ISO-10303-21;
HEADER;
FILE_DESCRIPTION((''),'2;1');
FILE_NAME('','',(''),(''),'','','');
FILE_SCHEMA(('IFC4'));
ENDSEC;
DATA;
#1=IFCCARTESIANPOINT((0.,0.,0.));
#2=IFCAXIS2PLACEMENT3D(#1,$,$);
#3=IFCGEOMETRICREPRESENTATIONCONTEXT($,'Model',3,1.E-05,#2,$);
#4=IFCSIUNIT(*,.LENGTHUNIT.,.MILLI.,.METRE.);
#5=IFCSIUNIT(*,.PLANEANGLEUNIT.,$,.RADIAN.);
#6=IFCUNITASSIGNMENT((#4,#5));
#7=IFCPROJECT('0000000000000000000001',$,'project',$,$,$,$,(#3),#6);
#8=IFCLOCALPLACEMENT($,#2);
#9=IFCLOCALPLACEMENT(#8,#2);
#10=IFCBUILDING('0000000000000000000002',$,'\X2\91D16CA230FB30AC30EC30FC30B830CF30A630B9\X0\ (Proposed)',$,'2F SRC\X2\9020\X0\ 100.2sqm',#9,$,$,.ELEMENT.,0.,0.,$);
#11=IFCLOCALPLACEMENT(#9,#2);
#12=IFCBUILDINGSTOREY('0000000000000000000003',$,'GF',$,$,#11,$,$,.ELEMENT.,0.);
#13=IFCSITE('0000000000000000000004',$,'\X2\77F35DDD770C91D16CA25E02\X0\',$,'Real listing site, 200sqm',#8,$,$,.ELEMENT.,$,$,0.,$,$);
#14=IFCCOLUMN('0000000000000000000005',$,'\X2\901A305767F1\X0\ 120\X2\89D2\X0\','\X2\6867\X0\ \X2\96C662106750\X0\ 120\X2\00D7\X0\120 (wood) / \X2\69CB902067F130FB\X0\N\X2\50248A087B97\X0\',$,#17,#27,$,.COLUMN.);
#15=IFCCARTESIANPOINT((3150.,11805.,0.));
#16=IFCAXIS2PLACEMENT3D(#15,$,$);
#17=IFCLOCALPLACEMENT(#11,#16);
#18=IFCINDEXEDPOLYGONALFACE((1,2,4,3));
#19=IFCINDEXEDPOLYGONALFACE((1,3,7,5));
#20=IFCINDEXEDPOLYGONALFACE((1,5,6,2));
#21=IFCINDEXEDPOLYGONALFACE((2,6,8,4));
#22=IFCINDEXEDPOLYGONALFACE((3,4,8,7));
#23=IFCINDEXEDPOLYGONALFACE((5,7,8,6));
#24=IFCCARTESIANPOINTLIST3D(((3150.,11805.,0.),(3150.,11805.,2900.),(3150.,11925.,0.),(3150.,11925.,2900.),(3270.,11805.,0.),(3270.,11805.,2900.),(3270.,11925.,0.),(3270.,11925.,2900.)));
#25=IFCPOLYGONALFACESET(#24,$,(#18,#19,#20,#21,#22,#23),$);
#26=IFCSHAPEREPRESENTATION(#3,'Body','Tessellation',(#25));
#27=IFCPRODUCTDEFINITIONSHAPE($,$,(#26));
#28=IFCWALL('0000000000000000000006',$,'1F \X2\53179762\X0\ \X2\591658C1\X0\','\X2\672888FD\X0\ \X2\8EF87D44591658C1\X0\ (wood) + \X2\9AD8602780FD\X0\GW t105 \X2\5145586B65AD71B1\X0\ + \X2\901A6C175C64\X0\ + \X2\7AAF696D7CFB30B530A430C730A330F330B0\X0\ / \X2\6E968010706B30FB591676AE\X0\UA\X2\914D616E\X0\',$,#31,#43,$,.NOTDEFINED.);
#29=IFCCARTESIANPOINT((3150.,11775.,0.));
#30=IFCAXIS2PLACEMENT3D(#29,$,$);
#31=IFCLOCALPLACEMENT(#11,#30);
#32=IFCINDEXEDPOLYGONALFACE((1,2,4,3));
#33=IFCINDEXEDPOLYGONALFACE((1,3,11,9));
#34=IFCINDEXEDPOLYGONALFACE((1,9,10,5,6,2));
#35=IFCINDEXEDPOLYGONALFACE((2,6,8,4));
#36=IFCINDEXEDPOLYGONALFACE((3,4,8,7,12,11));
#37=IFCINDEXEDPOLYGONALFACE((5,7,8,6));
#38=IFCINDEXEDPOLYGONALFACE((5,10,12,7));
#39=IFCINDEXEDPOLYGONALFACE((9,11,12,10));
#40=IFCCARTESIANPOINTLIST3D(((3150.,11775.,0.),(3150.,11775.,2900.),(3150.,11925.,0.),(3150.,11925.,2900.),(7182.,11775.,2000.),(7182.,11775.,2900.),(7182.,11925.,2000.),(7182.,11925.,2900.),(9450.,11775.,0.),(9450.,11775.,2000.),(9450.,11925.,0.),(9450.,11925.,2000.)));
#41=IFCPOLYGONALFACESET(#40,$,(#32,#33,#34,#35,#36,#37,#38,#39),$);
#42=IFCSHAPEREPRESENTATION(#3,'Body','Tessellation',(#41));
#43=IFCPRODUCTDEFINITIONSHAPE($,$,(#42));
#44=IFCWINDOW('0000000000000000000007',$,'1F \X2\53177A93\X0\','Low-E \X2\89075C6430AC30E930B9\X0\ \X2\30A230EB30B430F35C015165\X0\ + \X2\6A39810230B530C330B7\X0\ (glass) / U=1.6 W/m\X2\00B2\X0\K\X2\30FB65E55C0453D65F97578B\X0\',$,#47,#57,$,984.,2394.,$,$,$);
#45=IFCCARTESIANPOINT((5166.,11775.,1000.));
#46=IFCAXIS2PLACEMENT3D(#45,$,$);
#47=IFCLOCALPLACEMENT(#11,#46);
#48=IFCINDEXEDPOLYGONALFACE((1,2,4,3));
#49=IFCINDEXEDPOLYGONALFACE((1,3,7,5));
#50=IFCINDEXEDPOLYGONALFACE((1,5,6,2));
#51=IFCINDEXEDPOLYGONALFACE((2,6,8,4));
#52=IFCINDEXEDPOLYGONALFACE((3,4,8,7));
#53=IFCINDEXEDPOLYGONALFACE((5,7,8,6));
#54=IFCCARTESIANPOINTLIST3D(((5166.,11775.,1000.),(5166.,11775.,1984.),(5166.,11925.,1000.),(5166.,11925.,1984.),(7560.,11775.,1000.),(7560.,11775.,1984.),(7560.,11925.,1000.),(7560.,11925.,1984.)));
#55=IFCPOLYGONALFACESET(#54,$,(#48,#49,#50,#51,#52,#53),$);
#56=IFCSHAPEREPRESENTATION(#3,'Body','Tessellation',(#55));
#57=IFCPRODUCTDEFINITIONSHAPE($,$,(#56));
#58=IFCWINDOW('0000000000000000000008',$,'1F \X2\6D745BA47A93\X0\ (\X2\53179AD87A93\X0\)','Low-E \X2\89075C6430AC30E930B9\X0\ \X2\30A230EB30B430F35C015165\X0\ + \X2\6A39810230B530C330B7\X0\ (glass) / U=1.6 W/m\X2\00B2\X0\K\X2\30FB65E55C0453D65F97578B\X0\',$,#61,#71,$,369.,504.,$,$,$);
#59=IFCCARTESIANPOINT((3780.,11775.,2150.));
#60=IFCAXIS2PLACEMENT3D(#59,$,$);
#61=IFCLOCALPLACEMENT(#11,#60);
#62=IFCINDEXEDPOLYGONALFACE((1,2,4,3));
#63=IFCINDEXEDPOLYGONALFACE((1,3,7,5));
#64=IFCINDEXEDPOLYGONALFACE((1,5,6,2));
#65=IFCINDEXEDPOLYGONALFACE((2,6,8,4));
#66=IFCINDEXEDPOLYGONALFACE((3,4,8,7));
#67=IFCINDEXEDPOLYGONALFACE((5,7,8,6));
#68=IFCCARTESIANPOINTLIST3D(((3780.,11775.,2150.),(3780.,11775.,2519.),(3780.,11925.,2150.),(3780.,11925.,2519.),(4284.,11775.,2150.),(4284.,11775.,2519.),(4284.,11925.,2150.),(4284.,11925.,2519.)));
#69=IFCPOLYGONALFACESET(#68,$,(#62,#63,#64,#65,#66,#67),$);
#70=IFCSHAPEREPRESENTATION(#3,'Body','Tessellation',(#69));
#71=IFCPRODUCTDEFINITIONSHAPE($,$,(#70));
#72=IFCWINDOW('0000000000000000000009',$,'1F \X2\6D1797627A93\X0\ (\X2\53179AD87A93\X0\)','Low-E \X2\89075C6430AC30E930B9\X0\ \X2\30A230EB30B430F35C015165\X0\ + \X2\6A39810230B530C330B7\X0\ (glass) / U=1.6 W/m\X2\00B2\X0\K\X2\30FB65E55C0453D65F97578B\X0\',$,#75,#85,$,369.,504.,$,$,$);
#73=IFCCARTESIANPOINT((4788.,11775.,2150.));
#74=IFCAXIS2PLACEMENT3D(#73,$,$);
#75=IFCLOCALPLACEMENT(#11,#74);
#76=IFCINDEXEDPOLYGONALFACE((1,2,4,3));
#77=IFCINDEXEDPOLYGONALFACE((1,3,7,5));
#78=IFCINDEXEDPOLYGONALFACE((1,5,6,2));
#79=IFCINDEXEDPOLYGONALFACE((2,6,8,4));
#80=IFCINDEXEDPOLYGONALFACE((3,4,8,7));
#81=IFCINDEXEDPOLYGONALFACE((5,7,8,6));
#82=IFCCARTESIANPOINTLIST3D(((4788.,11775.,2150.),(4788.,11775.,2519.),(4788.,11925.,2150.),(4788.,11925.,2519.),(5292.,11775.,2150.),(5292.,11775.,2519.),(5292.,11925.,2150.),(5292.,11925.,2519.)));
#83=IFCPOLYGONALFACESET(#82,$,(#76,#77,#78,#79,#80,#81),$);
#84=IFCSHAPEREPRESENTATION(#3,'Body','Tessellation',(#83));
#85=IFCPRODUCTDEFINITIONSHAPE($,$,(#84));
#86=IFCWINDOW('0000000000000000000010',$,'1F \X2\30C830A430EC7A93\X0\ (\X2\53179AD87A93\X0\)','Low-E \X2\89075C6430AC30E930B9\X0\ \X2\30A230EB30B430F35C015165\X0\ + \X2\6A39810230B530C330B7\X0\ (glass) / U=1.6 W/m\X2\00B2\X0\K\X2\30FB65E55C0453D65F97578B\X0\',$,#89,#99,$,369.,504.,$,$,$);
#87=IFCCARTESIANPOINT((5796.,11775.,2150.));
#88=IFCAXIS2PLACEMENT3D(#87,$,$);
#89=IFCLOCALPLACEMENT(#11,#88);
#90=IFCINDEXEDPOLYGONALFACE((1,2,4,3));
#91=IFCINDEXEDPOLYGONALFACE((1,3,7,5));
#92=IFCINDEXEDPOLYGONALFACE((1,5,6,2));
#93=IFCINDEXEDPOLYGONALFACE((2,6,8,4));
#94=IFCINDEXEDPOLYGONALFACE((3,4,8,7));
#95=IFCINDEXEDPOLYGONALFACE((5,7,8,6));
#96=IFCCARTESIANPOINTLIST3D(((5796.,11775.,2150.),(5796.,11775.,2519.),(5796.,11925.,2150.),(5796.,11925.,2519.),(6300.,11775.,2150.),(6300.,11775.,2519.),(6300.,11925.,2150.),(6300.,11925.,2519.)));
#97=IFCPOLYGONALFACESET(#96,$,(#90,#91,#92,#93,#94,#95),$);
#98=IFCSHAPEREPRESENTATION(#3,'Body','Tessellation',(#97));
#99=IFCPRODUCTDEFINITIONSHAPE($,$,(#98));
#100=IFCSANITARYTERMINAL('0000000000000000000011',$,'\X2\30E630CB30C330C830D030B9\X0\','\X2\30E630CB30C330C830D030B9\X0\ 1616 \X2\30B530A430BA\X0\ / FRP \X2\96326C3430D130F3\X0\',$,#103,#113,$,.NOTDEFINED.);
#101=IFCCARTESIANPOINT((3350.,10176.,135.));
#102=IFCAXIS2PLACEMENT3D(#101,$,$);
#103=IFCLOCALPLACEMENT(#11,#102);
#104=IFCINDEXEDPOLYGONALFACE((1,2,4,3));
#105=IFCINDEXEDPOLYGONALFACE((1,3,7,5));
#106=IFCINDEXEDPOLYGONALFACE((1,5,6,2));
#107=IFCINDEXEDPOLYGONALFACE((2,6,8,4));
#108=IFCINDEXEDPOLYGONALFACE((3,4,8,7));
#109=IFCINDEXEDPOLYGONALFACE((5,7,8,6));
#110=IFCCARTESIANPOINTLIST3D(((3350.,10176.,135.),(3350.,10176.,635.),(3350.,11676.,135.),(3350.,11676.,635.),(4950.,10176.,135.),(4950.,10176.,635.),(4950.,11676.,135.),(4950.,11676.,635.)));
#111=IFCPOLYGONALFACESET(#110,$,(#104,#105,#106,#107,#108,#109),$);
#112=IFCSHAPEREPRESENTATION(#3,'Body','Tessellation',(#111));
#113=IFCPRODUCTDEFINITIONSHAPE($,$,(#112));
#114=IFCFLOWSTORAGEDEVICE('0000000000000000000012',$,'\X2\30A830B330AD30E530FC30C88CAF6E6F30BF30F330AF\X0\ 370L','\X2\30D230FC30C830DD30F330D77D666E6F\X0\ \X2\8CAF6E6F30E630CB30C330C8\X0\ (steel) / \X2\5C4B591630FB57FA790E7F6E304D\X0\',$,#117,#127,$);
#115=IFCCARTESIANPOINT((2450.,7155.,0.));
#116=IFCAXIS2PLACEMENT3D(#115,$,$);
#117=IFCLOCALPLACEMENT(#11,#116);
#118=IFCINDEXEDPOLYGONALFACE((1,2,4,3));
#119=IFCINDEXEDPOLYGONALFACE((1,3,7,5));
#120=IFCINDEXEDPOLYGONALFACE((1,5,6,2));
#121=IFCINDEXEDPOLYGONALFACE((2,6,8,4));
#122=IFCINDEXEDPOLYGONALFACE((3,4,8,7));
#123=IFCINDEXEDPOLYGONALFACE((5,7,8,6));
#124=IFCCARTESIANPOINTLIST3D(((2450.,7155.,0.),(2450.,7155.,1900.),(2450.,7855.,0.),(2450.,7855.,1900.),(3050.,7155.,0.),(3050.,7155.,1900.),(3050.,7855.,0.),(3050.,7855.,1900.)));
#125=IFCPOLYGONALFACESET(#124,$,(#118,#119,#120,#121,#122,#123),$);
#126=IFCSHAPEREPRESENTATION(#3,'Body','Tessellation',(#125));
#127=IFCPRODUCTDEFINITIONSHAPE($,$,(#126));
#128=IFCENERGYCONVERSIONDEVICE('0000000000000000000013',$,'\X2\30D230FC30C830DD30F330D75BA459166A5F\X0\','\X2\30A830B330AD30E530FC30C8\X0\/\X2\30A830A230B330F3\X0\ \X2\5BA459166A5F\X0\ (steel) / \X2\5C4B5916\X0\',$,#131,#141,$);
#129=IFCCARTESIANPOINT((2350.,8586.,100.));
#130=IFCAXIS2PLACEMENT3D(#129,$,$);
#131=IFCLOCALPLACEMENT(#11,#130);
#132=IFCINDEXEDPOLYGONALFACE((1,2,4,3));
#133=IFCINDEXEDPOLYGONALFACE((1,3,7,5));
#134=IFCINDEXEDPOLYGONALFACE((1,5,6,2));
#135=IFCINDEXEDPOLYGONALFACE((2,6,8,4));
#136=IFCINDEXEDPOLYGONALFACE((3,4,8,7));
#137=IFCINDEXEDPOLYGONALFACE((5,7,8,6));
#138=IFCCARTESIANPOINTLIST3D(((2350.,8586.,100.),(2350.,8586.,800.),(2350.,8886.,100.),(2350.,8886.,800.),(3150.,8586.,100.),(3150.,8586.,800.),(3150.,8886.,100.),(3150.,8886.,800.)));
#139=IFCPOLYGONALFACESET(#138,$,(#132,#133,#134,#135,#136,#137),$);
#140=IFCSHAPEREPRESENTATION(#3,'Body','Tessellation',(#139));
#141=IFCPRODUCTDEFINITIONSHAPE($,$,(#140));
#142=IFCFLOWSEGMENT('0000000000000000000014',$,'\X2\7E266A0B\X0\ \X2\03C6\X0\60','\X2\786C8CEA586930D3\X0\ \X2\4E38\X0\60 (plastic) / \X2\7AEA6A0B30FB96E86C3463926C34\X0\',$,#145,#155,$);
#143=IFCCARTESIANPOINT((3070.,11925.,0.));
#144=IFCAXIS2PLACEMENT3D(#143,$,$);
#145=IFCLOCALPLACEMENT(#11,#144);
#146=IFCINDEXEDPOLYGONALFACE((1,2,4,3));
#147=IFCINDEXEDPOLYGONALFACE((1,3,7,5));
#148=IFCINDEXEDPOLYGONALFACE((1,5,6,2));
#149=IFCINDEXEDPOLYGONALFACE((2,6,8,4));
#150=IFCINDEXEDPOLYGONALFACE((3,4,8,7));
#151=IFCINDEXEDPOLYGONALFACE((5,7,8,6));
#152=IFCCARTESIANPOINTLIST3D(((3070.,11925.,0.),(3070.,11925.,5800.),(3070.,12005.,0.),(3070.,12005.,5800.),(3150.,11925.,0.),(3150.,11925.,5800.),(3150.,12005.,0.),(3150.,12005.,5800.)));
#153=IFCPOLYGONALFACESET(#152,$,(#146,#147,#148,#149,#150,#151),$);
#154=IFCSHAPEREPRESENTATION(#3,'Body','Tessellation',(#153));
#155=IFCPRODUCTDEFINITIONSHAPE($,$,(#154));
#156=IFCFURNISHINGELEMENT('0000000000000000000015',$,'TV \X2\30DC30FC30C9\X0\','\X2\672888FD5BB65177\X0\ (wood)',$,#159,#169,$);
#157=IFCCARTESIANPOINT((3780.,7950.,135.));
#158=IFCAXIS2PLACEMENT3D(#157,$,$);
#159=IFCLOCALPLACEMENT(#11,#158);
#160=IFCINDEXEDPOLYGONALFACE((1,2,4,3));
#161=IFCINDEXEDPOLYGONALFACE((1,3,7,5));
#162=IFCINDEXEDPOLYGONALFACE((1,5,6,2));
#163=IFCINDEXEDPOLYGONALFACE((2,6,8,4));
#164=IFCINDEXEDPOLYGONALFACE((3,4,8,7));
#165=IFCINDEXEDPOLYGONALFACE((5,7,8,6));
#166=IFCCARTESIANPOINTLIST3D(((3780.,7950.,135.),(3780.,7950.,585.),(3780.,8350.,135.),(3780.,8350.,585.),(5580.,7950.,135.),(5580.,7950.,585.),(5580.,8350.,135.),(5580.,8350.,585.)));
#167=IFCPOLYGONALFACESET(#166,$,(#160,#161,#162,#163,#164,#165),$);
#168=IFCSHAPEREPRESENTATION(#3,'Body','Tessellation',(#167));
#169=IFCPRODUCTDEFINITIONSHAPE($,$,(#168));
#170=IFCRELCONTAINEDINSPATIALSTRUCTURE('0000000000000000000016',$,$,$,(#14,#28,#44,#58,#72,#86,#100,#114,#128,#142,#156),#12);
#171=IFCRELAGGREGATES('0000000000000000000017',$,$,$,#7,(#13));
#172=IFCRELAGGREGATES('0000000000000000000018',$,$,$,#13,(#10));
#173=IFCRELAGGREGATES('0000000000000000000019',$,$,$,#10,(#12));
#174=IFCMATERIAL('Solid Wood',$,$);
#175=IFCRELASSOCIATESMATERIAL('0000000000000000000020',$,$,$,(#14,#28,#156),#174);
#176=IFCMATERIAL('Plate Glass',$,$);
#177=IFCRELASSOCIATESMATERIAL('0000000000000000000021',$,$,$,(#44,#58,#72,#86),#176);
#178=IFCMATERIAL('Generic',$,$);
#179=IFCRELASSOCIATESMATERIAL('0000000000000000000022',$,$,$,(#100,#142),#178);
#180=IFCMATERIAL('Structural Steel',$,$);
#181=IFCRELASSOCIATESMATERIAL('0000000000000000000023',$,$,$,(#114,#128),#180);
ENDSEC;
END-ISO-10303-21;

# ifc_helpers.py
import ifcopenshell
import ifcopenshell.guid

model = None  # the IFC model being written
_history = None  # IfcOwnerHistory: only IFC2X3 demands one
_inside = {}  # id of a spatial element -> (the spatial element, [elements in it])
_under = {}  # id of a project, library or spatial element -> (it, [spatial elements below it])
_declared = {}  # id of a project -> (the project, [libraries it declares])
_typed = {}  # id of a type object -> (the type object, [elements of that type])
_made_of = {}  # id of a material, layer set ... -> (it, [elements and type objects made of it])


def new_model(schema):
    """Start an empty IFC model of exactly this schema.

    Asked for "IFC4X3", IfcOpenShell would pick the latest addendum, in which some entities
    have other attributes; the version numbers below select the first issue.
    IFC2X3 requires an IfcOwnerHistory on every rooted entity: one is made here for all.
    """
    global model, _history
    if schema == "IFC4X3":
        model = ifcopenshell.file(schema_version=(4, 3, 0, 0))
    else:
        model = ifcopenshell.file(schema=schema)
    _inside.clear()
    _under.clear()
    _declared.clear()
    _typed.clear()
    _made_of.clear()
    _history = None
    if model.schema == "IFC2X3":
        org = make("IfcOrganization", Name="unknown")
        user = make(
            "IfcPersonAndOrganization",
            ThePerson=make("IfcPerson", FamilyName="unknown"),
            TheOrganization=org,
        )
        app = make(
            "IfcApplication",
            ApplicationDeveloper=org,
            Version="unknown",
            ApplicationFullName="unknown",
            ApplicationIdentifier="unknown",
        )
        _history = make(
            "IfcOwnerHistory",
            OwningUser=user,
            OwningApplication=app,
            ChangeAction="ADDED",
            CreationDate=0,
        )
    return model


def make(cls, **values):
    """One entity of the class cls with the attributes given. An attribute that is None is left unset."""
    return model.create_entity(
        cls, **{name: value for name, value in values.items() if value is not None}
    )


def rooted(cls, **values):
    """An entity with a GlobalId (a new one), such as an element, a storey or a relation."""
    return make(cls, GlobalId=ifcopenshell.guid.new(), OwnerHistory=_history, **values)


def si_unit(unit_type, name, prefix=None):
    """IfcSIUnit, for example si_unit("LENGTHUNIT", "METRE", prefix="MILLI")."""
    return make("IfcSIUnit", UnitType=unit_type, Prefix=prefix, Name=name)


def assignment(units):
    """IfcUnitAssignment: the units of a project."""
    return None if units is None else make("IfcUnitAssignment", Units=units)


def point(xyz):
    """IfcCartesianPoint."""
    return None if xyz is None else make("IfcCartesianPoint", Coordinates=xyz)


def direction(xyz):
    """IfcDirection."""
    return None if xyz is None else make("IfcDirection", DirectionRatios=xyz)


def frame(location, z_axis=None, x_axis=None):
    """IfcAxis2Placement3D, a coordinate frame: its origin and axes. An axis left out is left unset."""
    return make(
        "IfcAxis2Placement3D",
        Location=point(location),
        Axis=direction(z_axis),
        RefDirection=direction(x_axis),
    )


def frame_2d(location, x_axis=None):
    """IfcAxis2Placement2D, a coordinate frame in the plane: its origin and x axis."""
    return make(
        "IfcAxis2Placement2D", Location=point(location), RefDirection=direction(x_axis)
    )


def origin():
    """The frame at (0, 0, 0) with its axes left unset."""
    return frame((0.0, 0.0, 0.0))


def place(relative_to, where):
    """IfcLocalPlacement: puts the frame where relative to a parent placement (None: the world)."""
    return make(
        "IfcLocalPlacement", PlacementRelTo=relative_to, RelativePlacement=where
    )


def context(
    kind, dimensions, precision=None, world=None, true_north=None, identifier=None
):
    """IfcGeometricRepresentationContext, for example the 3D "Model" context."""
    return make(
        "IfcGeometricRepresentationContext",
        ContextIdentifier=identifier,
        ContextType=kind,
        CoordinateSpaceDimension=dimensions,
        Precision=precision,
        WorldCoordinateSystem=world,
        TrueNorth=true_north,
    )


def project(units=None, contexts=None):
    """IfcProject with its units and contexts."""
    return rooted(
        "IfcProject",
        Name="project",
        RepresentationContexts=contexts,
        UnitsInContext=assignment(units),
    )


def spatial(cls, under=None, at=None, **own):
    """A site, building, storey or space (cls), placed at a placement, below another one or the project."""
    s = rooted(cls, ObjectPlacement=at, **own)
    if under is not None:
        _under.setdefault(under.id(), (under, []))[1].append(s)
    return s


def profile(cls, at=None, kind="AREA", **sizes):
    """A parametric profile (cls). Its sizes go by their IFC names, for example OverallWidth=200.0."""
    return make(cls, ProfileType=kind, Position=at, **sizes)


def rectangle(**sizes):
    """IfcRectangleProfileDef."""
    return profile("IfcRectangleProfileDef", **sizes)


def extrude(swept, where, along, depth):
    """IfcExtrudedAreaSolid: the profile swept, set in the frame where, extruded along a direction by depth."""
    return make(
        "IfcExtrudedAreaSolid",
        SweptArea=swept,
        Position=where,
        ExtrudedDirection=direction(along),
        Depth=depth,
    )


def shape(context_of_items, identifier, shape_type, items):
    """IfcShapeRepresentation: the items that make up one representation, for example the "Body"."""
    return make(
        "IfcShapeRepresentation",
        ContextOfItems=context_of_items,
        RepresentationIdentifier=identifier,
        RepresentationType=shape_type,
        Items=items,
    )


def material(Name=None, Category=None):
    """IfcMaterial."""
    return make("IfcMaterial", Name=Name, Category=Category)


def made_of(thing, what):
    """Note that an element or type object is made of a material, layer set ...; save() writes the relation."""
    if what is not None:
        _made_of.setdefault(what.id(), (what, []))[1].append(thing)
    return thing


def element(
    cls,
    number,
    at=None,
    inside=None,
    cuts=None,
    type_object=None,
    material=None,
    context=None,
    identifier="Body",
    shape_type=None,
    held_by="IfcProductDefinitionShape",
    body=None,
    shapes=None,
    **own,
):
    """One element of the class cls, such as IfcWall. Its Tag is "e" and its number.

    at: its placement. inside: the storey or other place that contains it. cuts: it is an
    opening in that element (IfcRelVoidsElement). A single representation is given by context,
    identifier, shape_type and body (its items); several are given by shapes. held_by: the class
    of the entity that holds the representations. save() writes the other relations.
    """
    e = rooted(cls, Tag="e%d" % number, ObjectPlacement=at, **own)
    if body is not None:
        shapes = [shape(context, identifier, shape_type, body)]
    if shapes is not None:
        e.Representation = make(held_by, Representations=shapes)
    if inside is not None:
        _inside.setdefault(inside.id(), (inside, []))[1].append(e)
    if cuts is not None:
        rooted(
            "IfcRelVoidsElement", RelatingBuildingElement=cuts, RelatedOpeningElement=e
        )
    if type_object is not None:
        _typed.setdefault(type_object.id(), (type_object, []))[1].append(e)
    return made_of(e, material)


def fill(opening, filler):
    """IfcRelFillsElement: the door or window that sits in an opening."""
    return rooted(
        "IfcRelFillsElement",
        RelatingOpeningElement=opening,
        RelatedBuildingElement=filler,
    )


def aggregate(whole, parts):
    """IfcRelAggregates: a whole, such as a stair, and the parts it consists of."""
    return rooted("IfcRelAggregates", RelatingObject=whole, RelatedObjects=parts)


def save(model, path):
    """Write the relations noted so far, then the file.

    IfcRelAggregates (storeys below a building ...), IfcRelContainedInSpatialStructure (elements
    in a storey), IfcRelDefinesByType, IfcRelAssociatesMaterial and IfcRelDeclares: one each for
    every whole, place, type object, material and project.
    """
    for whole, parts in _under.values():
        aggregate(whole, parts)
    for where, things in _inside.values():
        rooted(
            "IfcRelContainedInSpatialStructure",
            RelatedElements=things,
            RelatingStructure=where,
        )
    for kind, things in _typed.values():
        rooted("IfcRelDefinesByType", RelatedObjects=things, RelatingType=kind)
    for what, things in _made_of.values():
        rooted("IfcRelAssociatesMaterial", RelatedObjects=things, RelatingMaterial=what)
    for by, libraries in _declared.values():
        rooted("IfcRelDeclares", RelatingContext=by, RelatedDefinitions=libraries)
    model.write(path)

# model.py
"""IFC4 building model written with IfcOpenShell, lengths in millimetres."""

from ifc_helpers import new_model, si_unit, frame, frame_2d, origin, place, context, project, spatial, rectangle, extrude, material, element, fill, save


model = new_model("IFC4")

# Units and contexts
model_context = context("Model", 3, precision=1e-05, world=origin())
ifc_project = project(units=[si_unit("LENGTHUNIT", "METRE", prefix="MILLI"), si_unit("PLANEANGLEUNIT", "RADIAN")], contexts=[model_context])

# Site, building, storey
site_placement = place(None, origin())
site = spatial("IfcSite", under=ifc_project, at=site_placement, Name="石川県金沢市", ObjectType="Real listing site, 200sqm", CompositionType="ELEMENT", RefElevation=0.0)
building_placement = place(site_placement, origin())
building = spatial("IfcBuilding", under=site, at=building_placement, Name="金沢・ガレージハウス (Proposed)", ObjectType="2F SRC造 100.2sqm", CompositionType="ELEMENT", ElevationOfRefHeight=0.0, ElevationOfTerrain=0.0)
storey_placement = place(building_placement, origin())
storey = spatial("IfcBuildingStorey", under=building, at=storey_placement, Name="GF", CompositionType="ELEMENT", Elevation=0.0)

# Column
ifc_material_1 = material(Name="Solid Wood")
column_1_placement = place(storey_placement, frame((3150.0, 11805.0, 0.0)))
element("IfcColumn", 1, at=column_1_placement, inside=storey, material=ifc_material_1, Name="通し柱 120角", Description="桧 集成材 120×120 (wood) / 構造柱・N値計算", PredefinedType="COLUMN", context=model_context, shape_type="SweptSolid", body=[
    extrude(rectangle(XDim=120.0, YDim=120.0, at=frame_2d((60.0, 60.0))), frame((3150.0, 11805.0, 0.0)), (0.0, 0.0, 1.0), 2900.0),
])

# Wall, openings, windows
wall_1_placement = place(storey_placement, frame((3150.0, 11775.0, 0.0)))
wall_1 = element("IfcWall", 2, at=wall_1_placement, inside=storey, material=ifc_material_1, Name="1F 北面 外壁", Description="木製 軸組外壁 (wood) + 高性能GW t105 充填断熱 + 通気層 + 窯業系サイディング / 準耐火・外皮UA配慮", PredefinedType="NOTDEFINED", context=model_context, shape_type="SweptSolid", body=[
    extrude(rectangle(XDim=6300.0, YDim=150.0, at=frame_2d((3150.0, 75.0))), frame((3150.0, 11775.0, 0.0)), (0.0, 0.0, 1.0), 2900.0),
])
opening_1_placement = place(storey_placement, frame((5166.0, 11775.0, 1000.0)))
opening_1 = element("IfcOpeningElement", 3, at=opening_1_placement, cuts=wall_1, PredefinedType="NOTDEFINED", context=model_context, shape_type="SweptSolid", body=[
    extrude(rectangle(XDim=2394.0, YDim=150.0, at=frame_2d((1197.0, 75.0))), frame((5166.0, 11775.0, 1000.0)), (0.0, 0.0, 1.0), 984.0),
])
opening_2_placement = place(storey_placement, frame((3780.0, 11775.0, 2150.0)))
opening_2 = element("IfcOpeningElement", 4, at=opening_2_placement, cuts=wall_1, PredefinedType="NOTDEFINED", context=model_context, shape_type="SweptSolid", body=[
    extrude(rectangle(XDim=504.0, YDim=150.0, at=frame_2d((252.0, 75.0))), frame((3780.0, 11775.0, 2150.0)), (0.0, 0.0, 1.0), 369.0),
])
opening_3_placement = place(storey_placement, frame((4788.0, 11775.0, 2150.0)))
opening_3 = element("IfcOpeningElement", 5, at=opening_3_placement, cuts=wall_1, PredefinedType="NOTDEFINED", context=model_context, shape_type="SweptSolid", body=[
    extrude(rectangle(XDim=504.0, YDim=150.0, at=frame_2d((252.0, 75.0))), frame((4788.0, 11775.0, 2150.0)), (0.0, 0.0, 1.0), 369.0),
])
opening_4_placement = place(storey_placement, frame((5796.0, 11775.0, 2150.0)))
opening_4 = element("IfcOpeningElement", 6, at=opening_4_placement, cuts=wall_1, PredefinedType="NOTDEFINED", context=model_context, shape_type="SweptSolid", body=[
    extrude(rectangle(XDim=504.0, YDim=150.0, at=frame_2d((252.0, 75.0))), frame((5796.0, 11775.0, 2150.0)), (0.0, 0.0, 1.0), 369.0),
])
ifc_material_2 = material(Name="Plate Glass")
window_1_placement = place(storey_placement, frame((5166.0, 11775.0, 1000.0)))
window_1 = element("IfcWindow", 7, at=window_1_placement, inside=storey, material=ifc_material_2, Name="1F 北窓", Description="Low-E 複層ガラス アルゴン封入 + 樹脂サッシ (glass) / U=1.6 W/m²K・日射取得型", OverallHeight=984.0, OverallWidth=2394.0, context=model_context, shape_type="SweptSolid", body=[
    extrude(rectangle(XDim=2394.0, YDim=150.0, at=frame_2d((1197.0, 75.0))), frame((5166.0, 11775.0, 1000.0)), (0.0, 0.0, 1.0), 984.0),
])
fill(opening_1, window_1)
window_2_placement = place(storey_placement, frame((3780.0, 11775.0, 2150.0)))
window_2 = element("IfcWindow", 8, at=window_2_placement, inside=storey, material=ifc_material_2, Name="1F 浴室窓 (北高窓)", Description="Low-E 複層ガラス アルゴン封入 + 樹脂サッシ (glass) / U=1.6 W/m²K・日射取得型", OverallHeight=369.0, OverallWidth=504.0, context=model_context, shape_type="SweptSolid", body=[
    extrude(rectangle(XDim=504.0, YDim=150.0, at=frame_2d((252.0, 75.0))), frame((3780.0, 11775.0, 2150.0)), (0.0, 0.0, 1.0), 369.0),
])
fill(opening_2, window_2)
window_3_placement = place(storey_placement, frame((4788.0, 11775.0, 2150.0)))
window_3 = element("IfcWindow", 9, at=window_3_placement, inside=storey, material=ifc_material_2, Name="1F 洗面窓 (北高窓)", Description="Low-E 複層ガラス アルゴン封入 + 樹脂サッシ (glass) / U=1.6 W/m²K・日射取得型", OverallHeight=369.0, OverallWidth=504.0, context=model_context, shape_type="SweptSolid", body=[
    extrude(rectangle(XDim=504.0, YDim=150.0, at=frame_2d((252.0, 75.0))), frame((4788.0, 11775.0, 2150.0)), (0.0, 0.0, 1.0), 369.0),
])
fill(opening_3, window_3)
window_4_placement = place(storey_placement, frame((5796.0, 11775.0, 2150.0)))
window_4 = element("IfcWindow", 10, at=window_4_placement, inside=storey, material=ifc_material_2, Name="1F トイレ窓 (北高窓)", Description="Low-E 複層ガラス アルゴン封入 + 樹脂サッシ (glass) / U=1.6 W/m²K・日射取得型", OverallHeight=369.0, OverallWidth=504.0, context=model_context, shape_type="SweptSolid", body=[
    extrude(rectangle(XDim=504.0, YDim=150.0, at=frame_2d((252.0, 75.0))), frame((5796.0, 11775.0, 2150.0)), (0.0, 0.0, 1.0), 369.0),
])
fill(opening_4, window_4)

# Sanitary terminal
ifc_material_3 = material(Name="Generic")
sanitary_terminal_placement = place(storey_placement, frame((3350.0, 10176.0, 135.0)))
element("IfcSanitaryTerminal", 11, at=sanitary_terminal_placement, inside=storey, material=ifc_material_3, Name="ユニットバス", Description="ユニットバス 1616 サイズ / FRP 防水パン", PredefinedType="NOTDEFINED", context=model_context, shape_type="SweptSolid", body=[
    extrude(rectangle(XDim=1600.0, YDim=1500.0, at=frame_2d((800.0, 750.0))), frame((3350.0, 10176.0, 135.0)), (0.0, 0.0, 1.0), 500.0),
])

# Flow storage device
ifc_material_4 = material(Name="Structural Steel")
flow_storage_device_placement = place(storey_placement, frame((2450.0, 7155.0, 0.0)))
element("IfcFlowStorageDevice", 12, at=flow_storage_device_placement, inside=storey, material=ifc_material_4, Name="エコキュート貯湯タンク 370L", Description="ヒートポンプ給湯 貯湯ユニット (steel) / 屋外・基礎置き", context=model_context, shape_type="SweptSolid", body=[
    extrude(rectangle(XDim=600.0, YDim=700.0, at=frame_2d((300.0, 350.0))), frame((2450.0, 7155.0, 0.0)), (0.0, 0.0, 1.0), 1900.0),
])

# Energy conversion device
energy_conversion_device_placement = place(storey_placement, frame((2350.0, 8586.0, 100.0)))
element("IfcEnergyConversionDevice", 13, at=energy_conversion_device_placement, inside=storey, material=ifc_material_4, Name="ヒートポンプ室外機", Description="エコキュート/エアコン 室外機 (steel) / 屋外", context=model_context, shape_type="SweptSolid", body=[
    extrude(rectangle(XDim=800.0, YDim=300.0, at=frame_2d((400.0, 150.0))), frame((2350.0, 8586.0, 100.0)), (0.0, 0.0, 1.0), 700.0),
])

# Flow segment
flow_segment_placement = place(storey_placement, frame((3070.0, 11925.0, 0.0)))
element("IfcFlowSegment", 14, at=flow_segment_placement, inside=storey, material=ifc_material_3, Name="縦樋 φ60", Description="硬質塩ビ 丸60 (plastic) / 竪樋・雨水排水", context=model_context, shape_type="SweptSolid", body=[
    extrude(rectangle(XDim=80.0, YDim=80.0, at=frame_2d((40.0, 40.0))), frame((3070.0, 11925.0, 0.0)), (0.0, 0.0, 1.0), 5800.0),
])

# Furnishing element
furnishing_placement = place(storey_placement, frame((3780.0, 7950.0, 135.0)))
element("IfcFurnishingElement", 15, at=furnishing_placement, inside=storey, material=ifc_material_1, Name="TV ボード", Description="木製家具 (wood)", context=model_context, shape_type="SweptSolid", body=[
    extrude(rectangle(XDim=1800.0, YDim=400.0, at=frame_2d((900.0, 200.0))), frame((3780.0, 7950.0, 135.0)), (0.0, 0.0, 1.0), 450.0),
])

save(model, "model.ifc")
